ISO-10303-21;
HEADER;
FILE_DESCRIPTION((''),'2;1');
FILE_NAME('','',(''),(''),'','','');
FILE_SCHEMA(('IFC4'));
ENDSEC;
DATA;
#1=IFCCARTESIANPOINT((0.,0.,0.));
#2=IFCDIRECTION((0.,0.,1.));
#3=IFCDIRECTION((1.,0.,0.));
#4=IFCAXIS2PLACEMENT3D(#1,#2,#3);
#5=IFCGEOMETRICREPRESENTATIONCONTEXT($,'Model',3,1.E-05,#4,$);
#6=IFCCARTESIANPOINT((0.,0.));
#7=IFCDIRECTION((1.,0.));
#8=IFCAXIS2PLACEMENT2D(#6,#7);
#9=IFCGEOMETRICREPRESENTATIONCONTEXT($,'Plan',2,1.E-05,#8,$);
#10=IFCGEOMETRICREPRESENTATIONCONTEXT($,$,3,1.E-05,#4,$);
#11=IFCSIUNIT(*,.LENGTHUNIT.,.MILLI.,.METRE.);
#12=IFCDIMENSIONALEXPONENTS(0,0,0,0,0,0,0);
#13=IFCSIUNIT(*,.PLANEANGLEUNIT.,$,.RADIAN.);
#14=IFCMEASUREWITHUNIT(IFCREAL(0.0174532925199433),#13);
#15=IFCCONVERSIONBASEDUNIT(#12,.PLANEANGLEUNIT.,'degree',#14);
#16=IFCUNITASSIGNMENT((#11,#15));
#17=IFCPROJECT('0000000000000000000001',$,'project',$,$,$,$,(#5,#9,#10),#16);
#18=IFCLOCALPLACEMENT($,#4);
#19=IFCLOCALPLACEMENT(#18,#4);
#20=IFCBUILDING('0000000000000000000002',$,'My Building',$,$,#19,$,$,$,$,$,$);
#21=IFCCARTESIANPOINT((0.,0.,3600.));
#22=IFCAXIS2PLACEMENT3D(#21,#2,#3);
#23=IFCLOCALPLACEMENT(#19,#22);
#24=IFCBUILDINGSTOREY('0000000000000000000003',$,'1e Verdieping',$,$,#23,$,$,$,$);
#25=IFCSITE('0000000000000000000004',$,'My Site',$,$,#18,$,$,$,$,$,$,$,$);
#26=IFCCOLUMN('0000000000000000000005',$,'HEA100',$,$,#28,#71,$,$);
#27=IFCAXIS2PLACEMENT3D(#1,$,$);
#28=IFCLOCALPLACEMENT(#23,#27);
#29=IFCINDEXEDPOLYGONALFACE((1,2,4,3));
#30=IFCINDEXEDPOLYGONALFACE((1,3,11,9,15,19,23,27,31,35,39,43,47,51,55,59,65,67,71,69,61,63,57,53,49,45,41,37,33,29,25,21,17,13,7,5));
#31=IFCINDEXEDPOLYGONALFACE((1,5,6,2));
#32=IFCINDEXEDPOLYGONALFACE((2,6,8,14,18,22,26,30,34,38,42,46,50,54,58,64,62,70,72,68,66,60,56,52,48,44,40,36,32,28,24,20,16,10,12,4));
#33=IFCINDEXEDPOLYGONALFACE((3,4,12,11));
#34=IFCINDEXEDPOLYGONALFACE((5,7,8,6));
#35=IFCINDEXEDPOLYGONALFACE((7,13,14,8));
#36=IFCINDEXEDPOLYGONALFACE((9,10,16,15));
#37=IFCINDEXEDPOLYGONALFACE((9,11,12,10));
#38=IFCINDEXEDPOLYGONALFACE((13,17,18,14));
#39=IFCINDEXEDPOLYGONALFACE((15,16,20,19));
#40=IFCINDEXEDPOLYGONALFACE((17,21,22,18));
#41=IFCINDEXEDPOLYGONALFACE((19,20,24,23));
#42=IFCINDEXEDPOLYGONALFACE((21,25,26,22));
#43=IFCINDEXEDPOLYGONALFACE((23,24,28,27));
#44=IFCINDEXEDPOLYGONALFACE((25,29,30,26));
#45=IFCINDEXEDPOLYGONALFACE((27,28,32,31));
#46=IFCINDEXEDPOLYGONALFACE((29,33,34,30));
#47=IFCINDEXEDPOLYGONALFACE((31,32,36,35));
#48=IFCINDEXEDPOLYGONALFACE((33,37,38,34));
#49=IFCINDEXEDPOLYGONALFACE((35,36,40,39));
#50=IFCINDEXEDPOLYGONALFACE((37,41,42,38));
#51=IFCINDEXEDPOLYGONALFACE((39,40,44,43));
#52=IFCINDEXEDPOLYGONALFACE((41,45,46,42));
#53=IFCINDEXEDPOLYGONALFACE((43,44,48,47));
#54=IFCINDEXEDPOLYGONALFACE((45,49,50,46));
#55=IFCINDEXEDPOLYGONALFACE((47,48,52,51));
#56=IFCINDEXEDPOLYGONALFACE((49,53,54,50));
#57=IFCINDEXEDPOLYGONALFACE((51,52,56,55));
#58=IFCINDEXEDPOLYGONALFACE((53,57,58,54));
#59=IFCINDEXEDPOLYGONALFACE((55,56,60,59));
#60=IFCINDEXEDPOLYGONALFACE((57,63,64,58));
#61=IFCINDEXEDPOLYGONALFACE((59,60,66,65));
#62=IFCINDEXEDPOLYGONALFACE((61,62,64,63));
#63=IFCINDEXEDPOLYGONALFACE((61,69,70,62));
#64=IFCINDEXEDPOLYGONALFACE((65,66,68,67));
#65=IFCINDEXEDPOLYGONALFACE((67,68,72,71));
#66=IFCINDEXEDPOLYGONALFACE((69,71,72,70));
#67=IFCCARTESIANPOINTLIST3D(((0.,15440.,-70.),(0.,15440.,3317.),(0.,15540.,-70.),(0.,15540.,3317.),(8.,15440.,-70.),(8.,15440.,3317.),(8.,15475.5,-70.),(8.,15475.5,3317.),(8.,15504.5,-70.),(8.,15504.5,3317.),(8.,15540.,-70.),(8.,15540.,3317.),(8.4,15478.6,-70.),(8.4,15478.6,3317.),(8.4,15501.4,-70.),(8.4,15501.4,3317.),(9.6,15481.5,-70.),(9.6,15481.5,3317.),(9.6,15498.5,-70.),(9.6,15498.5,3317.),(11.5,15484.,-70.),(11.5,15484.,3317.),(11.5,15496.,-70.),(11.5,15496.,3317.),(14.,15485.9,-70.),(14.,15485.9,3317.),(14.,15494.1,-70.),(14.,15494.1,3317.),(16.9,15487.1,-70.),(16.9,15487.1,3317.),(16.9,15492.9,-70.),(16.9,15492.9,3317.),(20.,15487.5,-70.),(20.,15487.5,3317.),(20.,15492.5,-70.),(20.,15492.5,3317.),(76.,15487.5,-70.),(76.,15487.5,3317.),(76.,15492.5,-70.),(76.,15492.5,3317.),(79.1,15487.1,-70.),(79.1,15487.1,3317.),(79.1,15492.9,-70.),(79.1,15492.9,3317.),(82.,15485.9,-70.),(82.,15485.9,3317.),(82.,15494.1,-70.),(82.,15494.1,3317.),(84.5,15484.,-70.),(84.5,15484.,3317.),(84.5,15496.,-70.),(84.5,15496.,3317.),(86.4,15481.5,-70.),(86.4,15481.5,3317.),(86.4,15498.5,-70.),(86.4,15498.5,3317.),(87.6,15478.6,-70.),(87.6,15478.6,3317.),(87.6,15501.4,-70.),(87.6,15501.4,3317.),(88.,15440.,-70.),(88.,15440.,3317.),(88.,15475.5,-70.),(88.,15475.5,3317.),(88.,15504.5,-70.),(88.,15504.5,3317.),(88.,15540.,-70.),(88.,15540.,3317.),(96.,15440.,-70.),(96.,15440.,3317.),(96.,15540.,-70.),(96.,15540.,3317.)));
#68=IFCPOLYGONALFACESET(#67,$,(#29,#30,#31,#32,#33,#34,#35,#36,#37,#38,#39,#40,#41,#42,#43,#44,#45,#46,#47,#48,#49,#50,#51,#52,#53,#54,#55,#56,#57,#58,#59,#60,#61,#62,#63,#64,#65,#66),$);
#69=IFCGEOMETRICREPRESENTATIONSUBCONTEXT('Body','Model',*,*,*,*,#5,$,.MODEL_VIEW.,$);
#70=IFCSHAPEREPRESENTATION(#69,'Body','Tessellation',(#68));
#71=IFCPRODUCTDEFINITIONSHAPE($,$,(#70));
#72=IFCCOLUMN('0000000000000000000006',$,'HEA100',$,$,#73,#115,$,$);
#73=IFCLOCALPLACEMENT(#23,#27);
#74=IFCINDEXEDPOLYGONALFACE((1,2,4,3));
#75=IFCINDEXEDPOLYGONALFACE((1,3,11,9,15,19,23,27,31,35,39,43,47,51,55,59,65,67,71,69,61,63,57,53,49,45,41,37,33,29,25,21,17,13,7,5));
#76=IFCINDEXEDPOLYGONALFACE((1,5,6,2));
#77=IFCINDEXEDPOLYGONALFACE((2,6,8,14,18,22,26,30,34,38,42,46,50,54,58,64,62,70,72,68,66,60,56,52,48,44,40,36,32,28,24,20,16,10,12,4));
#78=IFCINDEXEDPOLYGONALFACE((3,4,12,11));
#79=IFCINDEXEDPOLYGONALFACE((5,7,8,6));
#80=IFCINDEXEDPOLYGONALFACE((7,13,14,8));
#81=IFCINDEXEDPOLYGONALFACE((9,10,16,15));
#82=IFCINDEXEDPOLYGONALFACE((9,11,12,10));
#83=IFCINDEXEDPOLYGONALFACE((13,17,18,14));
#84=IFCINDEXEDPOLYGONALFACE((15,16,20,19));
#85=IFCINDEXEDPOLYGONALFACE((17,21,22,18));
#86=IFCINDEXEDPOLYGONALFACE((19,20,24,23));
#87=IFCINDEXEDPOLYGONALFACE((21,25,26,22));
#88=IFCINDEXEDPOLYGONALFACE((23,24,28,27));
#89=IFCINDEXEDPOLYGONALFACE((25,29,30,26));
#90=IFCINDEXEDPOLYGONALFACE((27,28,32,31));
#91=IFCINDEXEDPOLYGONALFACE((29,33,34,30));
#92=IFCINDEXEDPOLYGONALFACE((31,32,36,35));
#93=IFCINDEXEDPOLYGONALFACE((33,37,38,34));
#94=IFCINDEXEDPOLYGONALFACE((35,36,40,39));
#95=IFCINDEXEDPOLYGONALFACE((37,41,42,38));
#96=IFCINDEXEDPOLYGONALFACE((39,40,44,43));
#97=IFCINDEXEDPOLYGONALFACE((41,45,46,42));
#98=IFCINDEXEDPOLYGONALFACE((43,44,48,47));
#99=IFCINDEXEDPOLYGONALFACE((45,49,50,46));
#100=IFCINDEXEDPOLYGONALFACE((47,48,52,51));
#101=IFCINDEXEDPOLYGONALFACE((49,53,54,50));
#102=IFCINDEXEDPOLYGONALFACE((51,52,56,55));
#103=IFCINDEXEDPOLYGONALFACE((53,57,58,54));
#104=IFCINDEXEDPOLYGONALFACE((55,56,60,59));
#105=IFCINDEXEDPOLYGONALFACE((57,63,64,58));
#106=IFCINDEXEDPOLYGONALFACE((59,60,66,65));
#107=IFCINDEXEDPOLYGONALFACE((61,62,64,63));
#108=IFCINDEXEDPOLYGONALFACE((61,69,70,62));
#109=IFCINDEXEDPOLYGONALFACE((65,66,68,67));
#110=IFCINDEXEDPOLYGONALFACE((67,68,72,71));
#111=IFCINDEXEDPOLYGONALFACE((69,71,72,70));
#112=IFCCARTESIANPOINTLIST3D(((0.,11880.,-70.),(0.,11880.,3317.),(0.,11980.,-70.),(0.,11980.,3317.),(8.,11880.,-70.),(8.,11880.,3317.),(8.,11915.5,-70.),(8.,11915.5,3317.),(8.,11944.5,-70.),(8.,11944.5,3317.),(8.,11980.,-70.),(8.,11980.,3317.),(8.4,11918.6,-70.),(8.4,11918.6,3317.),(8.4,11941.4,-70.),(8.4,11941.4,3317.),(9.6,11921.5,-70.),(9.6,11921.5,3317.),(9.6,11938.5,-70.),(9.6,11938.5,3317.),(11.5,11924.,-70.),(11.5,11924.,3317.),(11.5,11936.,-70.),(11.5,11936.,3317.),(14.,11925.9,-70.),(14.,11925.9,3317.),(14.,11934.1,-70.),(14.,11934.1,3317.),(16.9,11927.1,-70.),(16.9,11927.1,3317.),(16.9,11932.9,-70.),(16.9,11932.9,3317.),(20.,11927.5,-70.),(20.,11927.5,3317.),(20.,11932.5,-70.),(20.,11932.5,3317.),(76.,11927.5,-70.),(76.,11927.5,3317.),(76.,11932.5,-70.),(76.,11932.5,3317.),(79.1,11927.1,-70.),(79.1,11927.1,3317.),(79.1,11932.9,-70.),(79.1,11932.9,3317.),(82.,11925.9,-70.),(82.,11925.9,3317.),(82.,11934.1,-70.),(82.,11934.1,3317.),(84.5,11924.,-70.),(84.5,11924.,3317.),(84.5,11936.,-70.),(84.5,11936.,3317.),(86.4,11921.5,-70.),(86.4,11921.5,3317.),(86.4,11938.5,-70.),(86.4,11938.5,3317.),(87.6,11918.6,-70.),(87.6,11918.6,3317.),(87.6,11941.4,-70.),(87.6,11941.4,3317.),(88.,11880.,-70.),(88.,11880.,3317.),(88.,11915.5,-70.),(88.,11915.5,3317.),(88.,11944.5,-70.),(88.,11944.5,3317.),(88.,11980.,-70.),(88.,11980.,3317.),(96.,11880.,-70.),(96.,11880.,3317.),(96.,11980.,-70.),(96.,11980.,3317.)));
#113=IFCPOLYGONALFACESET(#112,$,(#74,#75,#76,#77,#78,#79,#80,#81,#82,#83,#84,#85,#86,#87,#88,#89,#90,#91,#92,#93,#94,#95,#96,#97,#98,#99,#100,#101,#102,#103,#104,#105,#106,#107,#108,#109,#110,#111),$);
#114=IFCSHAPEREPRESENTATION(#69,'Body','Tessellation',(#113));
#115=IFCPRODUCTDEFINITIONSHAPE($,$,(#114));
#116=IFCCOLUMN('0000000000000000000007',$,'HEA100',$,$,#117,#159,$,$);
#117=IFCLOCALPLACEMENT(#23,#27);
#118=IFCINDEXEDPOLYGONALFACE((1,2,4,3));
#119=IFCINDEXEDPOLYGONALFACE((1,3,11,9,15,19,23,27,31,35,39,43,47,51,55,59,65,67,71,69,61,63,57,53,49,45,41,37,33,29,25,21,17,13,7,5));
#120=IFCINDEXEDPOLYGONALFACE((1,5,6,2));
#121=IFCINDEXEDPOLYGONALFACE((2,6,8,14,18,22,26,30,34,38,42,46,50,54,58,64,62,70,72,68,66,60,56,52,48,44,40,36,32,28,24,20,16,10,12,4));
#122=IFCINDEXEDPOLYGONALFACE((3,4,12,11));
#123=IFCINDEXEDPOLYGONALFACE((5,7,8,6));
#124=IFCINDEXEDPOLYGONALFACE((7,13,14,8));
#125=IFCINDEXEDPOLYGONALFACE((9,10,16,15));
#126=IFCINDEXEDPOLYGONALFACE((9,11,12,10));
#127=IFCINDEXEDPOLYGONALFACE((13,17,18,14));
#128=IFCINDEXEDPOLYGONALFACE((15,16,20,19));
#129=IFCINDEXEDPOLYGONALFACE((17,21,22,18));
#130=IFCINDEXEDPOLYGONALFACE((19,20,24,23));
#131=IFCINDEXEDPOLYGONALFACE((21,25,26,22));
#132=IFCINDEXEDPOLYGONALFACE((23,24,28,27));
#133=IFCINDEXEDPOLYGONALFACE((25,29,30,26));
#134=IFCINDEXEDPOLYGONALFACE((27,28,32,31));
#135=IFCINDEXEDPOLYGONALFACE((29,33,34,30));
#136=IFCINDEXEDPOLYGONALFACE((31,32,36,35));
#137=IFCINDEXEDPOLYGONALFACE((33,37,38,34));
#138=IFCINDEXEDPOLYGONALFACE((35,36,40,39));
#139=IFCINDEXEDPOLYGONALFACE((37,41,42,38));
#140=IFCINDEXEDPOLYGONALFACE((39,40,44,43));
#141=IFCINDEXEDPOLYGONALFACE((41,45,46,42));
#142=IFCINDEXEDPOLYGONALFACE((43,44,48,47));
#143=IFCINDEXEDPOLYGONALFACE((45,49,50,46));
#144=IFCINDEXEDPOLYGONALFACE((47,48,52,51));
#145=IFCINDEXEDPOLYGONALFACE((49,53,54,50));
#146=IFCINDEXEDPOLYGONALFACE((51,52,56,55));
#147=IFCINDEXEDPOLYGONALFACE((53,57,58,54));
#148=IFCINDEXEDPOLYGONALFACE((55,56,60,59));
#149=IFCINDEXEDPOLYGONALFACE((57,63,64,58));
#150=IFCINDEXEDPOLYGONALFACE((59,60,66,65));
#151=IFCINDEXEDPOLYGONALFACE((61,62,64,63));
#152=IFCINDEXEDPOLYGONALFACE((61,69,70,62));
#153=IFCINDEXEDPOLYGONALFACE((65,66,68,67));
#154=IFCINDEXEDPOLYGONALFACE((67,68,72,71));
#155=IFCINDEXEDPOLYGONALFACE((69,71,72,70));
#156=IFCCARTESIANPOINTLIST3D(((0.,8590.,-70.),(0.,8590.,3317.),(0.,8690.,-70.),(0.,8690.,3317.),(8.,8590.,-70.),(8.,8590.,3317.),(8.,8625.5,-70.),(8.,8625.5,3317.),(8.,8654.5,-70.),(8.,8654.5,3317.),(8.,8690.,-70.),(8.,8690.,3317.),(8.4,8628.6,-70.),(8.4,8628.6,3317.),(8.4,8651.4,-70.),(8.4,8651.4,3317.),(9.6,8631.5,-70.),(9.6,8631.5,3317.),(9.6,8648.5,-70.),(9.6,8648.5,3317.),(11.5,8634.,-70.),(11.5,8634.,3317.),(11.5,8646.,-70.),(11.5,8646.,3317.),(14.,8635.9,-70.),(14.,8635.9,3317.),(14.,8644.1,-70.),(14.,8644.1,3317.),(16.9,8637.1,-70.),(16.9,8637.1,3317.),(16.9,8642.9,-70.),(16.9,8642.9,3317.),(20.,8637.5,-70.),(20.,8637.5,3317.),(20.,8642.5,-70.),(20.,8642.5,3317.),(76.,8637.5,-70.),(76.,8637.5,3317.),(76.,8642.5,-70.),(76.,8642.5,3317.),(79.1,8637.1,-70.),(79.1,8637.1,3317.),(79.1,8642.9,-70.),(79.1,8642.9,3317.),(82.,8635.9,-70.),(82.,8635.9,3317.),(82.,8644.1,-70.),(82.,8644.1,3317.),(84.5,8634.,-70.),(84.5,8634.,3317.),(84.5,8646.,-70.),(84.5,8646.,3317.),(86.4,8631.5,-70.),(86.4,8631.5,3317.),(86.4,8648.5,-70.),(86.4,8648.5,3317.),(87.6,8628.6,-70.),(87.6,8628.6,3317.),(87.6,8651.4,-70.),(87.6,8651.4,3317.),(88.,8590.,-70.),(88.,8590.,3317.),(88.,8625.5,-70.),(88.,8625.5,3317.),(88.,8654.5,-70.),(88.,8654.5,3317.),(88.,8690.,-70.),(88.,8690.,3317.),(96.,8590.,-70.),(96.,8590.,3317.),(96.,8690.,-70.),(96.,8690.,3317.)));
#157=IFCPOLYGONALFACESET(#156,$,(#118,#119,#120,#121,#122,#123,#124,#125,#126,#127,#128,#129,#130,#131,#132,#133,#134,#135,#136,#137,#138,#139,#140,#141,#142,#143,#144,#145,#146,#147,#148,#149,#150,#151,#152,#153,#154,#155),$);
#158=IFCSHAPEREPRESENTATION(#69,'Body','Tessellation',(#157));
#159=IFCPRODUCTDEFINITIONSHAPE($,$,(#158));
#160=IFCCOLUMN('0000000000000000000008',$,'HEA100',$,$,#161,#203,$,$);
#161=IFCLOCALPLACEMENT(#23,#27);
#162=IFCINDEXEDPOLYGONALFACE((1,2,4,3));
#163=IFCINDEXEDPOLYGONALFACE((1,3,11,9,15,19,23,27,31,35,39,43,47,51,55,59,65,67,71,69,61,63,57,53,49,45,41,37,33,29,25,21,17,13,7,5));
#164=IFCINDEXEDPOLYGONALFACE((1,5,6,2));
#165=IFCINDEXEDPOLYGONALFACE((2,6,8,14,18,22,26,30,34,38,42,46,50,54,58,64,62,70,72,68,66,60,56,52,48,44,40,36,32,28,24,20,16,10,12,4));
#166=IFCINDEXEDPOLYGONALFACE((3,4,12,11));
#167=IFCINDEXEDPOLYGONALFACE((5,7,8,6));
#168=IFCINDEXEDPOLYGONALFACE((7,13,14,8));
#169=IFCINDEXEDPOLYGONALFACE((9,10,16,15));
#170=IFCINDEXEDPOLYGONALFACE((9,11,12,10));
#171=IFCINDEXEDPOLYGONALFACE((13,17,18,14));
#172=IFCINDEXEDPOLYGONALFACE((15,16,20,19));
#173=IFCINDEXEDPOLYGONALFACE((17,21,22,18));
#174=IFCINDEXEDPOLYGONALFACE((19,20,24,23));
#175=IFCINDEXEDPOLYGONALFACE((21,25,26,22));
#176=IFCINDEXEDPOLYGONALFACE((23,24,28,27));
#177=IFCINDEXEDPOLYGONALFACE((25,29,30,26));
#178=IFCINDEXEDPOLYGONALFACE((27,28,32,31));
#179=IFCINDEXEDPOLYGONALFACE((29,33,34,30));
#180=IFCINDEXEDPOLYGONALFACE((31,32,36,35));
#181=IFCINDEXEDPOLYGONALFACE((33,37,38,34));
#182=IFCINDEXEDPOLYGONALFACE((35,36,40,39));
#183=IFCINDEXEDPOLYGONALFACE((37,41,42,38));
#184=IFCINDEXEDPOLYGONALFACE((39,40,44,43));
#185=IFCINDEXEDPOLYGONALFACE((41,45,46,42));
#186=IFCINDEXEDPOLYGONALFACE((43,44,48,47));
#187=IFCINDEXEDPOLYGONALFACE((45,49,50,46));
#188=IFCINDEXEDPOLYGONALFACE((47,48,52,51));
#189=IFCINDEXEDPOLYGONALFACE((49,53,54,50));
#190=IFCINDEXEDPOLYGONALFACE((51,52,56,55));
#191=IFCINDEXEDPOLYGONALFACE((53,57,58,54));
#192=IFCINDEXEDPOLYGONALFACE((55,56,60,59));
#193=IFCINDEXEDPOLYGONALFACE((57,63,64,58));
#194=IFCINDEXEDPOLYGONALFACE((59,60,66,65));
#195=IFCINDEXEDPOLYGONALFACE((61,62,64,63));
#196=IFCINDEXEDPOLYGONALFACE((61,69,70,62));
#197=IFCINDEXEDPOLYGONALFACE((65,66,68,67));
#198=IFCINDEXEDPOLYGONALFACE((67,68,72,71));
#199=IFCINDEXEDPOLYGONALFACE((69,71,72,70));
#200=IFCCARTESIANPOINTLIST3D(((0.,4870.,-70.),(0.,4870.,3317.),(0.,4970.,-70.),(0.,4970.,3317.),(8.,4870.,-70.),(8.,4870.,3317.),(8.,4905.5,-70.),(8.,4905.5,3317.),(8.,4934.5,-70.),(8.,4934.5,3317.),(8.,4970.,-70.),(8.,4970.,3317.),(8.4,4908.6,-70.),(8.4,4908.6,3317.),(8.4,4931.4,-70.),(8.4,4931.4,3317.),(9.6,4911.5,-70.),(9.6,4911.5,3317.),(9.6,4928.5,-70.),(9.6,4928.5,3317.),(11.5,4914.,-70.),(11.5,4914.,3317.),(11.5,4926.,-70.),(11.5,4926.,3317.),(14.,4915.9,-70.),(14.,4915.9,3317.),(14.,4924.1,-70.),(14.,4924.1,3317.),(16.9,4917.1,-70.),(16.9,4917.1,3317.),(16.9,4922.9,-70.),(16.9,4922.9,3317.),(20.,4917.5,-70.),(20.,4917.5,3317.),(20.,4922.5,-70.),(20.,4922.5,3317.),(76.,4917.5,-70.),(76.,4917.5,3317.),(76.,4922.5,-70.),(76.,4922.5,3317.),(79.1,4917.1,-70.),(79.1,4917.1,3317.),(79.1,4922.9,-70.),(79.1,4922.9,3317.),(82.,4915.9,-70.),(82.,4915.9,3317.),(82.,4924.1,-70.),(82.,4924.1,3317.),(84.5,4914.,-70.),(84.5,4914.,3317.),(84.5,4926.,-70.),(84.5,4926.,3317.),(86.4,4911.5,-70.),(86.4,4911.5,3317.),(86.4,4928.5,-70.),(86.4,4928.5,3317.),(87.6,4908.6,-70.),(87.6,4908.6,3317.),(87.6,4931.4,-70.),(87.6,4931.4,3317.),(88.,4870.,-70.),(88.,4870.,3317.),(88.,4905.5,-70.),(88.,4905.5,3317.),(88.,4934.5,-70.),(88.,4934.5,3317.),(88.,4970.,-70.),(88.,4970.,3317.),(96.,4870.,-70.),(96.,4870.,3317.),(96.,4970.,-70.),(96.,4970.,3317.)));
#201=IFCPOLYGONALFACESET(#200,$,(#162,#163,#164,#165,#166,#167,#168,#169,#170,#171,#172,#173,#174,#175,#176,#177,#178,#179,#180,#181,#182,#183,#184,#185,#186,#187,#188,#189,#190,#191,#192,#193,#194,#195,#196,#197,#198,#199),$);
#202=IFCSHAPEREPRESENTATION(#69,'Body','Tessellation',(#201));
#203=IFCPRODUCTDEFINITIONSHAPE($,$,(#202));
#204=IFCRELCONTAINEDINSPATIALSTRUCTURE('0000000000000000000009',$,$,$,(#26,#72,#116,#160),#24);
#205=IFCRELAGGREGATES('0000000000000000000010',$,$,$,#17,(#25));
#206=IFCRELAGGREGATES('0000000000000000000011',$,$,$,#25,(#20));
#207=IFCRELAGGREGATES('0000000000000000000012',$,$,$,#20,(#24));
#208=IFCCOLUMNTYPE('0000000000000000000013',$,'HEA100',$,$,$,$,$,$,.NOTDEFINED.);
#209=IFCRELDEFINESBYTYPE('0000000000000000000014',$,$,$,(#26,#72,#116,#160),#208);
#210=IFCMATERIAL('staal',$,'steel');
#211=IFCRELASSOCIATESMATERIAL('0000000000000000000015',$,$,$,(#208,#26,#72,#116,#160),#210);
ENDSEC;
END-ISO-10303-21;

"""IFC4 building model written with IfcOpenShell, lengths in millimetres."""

from ifc_helpers import new_model, entity, si_unit, converted_unit, frame, origin_with_axes, origin_2d_with_axis, place, context, subcontext, project, spatial, i_section, extrude, material, material_profile, profile_set, profile_usage, type_object, element, save


model = new_model("IFC4")

# Units and contexts
model_context = context("Model", 3, precision=1e-05, world=origin_with_axes())
plan_context = context("Plan", 2, precision=1e-05, world=origin_2d_with_axis())
context_of_model = context(None, 3, precision=1e-05, world=origin_with_axes())
body_context = subcontext(model_context, "Body", "Model", "MODEL_VIEW")
ifc_project = project(units=[si_unit("LENGTHUNIT", "METRE", prefix="MILLI"), converted_unit("PLANEANGLEUNIT", "degree", entity("IfcReal", 0.0174532925199433), si_unit("PLANEANGLEUNIT", "RADIAN"), dimensions=[0, 0, 0, 0, 0, 0, 0])], contexts=[model_context, plan_context, context_of_model])

# Site, building, storey
site_placement = place(None, origin_with_axes())
site = spatial("IfcSite", under=ifc_project, at=site_placement, Name="My Site")
building_placement = place(site_placement, origin_with_axes())
building = spatial("IfcBuilding", under=site, at=building_placement, Name="My Building")
storey_placement = place(building_placement, frame((0.0, 0.0, 3600.0), z_axis=(0.0, 0.0, 1.0), x_axis=(1.0, 0.0, 0.0)))
storey = spatial("IfcBuildingStorey", under=building, at=storey_placement, Name="1e Verdieping")

# Columns
ifc_material_1 = material(Name="staal", Category="steel")
ifc_material_profile_1 = material_profile(ifc_material_1, i_section(OverallWidth=100.0, OverallDepth=96.0, WebThickness=5.0, FlangeThickness=8.0, FilletRadius=12.0))
ifc_profile_set_1 = profile_set([ifc_material_profile_1], Name="HEA100")
column_type_1 = type_object("IfcColumnType", Name="HEA100", PredefinedType="NOTDEFINED", material=ifc_profile_set_1)
ifc_profile_usage_1 = profile_usage(ifc_profile_set_1)
column_1_placement = place(storey_placement, frame((48.0, 15490.0, -70.0), z_axis=(0.0, 0.0, 1.0), x_axis=(0.0, 1.0, 0.0)))
element("IfcColumn", 1, at=column_1_placement, inside=storey, type_object=column_type_1, material=ifc_profile_usage_1, Name="HEA100", context=body_context, shape_type="SweptSolid", body=[
    extrude(i_section(OverallWidth=100.0, OverallDepth=96.0, WebThickness=5.0, FlangeThickness=8.0, FilletRadius=12.0), origin_with_axes(), (0.0, 0.0, 1.0), 3387.0),
])
ifc_profile_usage_2 = profile_usage(ifc_profile_set_1)
column_2_placement = place(storey_placement, frame((48.0, 11930.0, -70.0), z_axis=(0.0, 0.0, 1.0), x_axis=(0.0, 1.0, 0.0)))
element("IfcColumn", 2, at=column_2_placement, inside=storey, type_object=column_type_1, material=ifc_profile_usage_2, Name="HEA100", context=body_context, shape_type="SweptSolid", body=[
    extrude(i_section(OverallWidth=100.0, OverallDepth=96.0, WebThickness=5.0, FlangeThickness=8.0, FilletRadius=12.0), origin_with_axes(), (0.0, 0.0, 1.0), 3387.0),
])
ifc_profile_usage_3 = profile_usage(ifc_profile_set_1)
column_3_placement = place(storey_placement, frame((48.0, 8640.0, -70.0), z_axis=(0.0, 0.0, 1.0), x_axis=(0.0, 1.0, 0.0)))
element("IfcColumn", 3, at=column_3_placement, inside=storey, type_object=column_type_1, material=ifc_profile_usage_3, Name="HEA100", context=body_context, shape_type="SweptSolid", body=[
    extrude(i_section(OverallWidth=100.0, OverallDepth=96.0, WebThickness=5.0, FlangeThickness=8.0, FilletRadius=12.0), origin_with_axes(), (0.0, 0.0, 1.0), 3387.0),
])
ifc_profile_usage_4 = profile_usage(ifc_profile_set_1)
column_4_placement = place(storey_placement, frame((48.0, 4920.0, -70.0), z_axis=(0.0, 0.0, 1.0), x_axis=(0.0, 1.0, 0.0)))
element("IfcColumn", 4, at=column_4_placement, inside=storey, type_object=column_type_1, material=ifc_profile_usage_4, Name="HEA100", context=body_context, shape_type="SweptSolid", body=[
    extrude(i_section(OverallWidth=100.0, OverallDepth=96.0, WebThickness=5.0, FlangeThickness=8.0, FilletRadius=12.0), origin_with_axes(), (0.0, 0.0, 1.0), 3387.0),
])

save(model, "model.ifc")
